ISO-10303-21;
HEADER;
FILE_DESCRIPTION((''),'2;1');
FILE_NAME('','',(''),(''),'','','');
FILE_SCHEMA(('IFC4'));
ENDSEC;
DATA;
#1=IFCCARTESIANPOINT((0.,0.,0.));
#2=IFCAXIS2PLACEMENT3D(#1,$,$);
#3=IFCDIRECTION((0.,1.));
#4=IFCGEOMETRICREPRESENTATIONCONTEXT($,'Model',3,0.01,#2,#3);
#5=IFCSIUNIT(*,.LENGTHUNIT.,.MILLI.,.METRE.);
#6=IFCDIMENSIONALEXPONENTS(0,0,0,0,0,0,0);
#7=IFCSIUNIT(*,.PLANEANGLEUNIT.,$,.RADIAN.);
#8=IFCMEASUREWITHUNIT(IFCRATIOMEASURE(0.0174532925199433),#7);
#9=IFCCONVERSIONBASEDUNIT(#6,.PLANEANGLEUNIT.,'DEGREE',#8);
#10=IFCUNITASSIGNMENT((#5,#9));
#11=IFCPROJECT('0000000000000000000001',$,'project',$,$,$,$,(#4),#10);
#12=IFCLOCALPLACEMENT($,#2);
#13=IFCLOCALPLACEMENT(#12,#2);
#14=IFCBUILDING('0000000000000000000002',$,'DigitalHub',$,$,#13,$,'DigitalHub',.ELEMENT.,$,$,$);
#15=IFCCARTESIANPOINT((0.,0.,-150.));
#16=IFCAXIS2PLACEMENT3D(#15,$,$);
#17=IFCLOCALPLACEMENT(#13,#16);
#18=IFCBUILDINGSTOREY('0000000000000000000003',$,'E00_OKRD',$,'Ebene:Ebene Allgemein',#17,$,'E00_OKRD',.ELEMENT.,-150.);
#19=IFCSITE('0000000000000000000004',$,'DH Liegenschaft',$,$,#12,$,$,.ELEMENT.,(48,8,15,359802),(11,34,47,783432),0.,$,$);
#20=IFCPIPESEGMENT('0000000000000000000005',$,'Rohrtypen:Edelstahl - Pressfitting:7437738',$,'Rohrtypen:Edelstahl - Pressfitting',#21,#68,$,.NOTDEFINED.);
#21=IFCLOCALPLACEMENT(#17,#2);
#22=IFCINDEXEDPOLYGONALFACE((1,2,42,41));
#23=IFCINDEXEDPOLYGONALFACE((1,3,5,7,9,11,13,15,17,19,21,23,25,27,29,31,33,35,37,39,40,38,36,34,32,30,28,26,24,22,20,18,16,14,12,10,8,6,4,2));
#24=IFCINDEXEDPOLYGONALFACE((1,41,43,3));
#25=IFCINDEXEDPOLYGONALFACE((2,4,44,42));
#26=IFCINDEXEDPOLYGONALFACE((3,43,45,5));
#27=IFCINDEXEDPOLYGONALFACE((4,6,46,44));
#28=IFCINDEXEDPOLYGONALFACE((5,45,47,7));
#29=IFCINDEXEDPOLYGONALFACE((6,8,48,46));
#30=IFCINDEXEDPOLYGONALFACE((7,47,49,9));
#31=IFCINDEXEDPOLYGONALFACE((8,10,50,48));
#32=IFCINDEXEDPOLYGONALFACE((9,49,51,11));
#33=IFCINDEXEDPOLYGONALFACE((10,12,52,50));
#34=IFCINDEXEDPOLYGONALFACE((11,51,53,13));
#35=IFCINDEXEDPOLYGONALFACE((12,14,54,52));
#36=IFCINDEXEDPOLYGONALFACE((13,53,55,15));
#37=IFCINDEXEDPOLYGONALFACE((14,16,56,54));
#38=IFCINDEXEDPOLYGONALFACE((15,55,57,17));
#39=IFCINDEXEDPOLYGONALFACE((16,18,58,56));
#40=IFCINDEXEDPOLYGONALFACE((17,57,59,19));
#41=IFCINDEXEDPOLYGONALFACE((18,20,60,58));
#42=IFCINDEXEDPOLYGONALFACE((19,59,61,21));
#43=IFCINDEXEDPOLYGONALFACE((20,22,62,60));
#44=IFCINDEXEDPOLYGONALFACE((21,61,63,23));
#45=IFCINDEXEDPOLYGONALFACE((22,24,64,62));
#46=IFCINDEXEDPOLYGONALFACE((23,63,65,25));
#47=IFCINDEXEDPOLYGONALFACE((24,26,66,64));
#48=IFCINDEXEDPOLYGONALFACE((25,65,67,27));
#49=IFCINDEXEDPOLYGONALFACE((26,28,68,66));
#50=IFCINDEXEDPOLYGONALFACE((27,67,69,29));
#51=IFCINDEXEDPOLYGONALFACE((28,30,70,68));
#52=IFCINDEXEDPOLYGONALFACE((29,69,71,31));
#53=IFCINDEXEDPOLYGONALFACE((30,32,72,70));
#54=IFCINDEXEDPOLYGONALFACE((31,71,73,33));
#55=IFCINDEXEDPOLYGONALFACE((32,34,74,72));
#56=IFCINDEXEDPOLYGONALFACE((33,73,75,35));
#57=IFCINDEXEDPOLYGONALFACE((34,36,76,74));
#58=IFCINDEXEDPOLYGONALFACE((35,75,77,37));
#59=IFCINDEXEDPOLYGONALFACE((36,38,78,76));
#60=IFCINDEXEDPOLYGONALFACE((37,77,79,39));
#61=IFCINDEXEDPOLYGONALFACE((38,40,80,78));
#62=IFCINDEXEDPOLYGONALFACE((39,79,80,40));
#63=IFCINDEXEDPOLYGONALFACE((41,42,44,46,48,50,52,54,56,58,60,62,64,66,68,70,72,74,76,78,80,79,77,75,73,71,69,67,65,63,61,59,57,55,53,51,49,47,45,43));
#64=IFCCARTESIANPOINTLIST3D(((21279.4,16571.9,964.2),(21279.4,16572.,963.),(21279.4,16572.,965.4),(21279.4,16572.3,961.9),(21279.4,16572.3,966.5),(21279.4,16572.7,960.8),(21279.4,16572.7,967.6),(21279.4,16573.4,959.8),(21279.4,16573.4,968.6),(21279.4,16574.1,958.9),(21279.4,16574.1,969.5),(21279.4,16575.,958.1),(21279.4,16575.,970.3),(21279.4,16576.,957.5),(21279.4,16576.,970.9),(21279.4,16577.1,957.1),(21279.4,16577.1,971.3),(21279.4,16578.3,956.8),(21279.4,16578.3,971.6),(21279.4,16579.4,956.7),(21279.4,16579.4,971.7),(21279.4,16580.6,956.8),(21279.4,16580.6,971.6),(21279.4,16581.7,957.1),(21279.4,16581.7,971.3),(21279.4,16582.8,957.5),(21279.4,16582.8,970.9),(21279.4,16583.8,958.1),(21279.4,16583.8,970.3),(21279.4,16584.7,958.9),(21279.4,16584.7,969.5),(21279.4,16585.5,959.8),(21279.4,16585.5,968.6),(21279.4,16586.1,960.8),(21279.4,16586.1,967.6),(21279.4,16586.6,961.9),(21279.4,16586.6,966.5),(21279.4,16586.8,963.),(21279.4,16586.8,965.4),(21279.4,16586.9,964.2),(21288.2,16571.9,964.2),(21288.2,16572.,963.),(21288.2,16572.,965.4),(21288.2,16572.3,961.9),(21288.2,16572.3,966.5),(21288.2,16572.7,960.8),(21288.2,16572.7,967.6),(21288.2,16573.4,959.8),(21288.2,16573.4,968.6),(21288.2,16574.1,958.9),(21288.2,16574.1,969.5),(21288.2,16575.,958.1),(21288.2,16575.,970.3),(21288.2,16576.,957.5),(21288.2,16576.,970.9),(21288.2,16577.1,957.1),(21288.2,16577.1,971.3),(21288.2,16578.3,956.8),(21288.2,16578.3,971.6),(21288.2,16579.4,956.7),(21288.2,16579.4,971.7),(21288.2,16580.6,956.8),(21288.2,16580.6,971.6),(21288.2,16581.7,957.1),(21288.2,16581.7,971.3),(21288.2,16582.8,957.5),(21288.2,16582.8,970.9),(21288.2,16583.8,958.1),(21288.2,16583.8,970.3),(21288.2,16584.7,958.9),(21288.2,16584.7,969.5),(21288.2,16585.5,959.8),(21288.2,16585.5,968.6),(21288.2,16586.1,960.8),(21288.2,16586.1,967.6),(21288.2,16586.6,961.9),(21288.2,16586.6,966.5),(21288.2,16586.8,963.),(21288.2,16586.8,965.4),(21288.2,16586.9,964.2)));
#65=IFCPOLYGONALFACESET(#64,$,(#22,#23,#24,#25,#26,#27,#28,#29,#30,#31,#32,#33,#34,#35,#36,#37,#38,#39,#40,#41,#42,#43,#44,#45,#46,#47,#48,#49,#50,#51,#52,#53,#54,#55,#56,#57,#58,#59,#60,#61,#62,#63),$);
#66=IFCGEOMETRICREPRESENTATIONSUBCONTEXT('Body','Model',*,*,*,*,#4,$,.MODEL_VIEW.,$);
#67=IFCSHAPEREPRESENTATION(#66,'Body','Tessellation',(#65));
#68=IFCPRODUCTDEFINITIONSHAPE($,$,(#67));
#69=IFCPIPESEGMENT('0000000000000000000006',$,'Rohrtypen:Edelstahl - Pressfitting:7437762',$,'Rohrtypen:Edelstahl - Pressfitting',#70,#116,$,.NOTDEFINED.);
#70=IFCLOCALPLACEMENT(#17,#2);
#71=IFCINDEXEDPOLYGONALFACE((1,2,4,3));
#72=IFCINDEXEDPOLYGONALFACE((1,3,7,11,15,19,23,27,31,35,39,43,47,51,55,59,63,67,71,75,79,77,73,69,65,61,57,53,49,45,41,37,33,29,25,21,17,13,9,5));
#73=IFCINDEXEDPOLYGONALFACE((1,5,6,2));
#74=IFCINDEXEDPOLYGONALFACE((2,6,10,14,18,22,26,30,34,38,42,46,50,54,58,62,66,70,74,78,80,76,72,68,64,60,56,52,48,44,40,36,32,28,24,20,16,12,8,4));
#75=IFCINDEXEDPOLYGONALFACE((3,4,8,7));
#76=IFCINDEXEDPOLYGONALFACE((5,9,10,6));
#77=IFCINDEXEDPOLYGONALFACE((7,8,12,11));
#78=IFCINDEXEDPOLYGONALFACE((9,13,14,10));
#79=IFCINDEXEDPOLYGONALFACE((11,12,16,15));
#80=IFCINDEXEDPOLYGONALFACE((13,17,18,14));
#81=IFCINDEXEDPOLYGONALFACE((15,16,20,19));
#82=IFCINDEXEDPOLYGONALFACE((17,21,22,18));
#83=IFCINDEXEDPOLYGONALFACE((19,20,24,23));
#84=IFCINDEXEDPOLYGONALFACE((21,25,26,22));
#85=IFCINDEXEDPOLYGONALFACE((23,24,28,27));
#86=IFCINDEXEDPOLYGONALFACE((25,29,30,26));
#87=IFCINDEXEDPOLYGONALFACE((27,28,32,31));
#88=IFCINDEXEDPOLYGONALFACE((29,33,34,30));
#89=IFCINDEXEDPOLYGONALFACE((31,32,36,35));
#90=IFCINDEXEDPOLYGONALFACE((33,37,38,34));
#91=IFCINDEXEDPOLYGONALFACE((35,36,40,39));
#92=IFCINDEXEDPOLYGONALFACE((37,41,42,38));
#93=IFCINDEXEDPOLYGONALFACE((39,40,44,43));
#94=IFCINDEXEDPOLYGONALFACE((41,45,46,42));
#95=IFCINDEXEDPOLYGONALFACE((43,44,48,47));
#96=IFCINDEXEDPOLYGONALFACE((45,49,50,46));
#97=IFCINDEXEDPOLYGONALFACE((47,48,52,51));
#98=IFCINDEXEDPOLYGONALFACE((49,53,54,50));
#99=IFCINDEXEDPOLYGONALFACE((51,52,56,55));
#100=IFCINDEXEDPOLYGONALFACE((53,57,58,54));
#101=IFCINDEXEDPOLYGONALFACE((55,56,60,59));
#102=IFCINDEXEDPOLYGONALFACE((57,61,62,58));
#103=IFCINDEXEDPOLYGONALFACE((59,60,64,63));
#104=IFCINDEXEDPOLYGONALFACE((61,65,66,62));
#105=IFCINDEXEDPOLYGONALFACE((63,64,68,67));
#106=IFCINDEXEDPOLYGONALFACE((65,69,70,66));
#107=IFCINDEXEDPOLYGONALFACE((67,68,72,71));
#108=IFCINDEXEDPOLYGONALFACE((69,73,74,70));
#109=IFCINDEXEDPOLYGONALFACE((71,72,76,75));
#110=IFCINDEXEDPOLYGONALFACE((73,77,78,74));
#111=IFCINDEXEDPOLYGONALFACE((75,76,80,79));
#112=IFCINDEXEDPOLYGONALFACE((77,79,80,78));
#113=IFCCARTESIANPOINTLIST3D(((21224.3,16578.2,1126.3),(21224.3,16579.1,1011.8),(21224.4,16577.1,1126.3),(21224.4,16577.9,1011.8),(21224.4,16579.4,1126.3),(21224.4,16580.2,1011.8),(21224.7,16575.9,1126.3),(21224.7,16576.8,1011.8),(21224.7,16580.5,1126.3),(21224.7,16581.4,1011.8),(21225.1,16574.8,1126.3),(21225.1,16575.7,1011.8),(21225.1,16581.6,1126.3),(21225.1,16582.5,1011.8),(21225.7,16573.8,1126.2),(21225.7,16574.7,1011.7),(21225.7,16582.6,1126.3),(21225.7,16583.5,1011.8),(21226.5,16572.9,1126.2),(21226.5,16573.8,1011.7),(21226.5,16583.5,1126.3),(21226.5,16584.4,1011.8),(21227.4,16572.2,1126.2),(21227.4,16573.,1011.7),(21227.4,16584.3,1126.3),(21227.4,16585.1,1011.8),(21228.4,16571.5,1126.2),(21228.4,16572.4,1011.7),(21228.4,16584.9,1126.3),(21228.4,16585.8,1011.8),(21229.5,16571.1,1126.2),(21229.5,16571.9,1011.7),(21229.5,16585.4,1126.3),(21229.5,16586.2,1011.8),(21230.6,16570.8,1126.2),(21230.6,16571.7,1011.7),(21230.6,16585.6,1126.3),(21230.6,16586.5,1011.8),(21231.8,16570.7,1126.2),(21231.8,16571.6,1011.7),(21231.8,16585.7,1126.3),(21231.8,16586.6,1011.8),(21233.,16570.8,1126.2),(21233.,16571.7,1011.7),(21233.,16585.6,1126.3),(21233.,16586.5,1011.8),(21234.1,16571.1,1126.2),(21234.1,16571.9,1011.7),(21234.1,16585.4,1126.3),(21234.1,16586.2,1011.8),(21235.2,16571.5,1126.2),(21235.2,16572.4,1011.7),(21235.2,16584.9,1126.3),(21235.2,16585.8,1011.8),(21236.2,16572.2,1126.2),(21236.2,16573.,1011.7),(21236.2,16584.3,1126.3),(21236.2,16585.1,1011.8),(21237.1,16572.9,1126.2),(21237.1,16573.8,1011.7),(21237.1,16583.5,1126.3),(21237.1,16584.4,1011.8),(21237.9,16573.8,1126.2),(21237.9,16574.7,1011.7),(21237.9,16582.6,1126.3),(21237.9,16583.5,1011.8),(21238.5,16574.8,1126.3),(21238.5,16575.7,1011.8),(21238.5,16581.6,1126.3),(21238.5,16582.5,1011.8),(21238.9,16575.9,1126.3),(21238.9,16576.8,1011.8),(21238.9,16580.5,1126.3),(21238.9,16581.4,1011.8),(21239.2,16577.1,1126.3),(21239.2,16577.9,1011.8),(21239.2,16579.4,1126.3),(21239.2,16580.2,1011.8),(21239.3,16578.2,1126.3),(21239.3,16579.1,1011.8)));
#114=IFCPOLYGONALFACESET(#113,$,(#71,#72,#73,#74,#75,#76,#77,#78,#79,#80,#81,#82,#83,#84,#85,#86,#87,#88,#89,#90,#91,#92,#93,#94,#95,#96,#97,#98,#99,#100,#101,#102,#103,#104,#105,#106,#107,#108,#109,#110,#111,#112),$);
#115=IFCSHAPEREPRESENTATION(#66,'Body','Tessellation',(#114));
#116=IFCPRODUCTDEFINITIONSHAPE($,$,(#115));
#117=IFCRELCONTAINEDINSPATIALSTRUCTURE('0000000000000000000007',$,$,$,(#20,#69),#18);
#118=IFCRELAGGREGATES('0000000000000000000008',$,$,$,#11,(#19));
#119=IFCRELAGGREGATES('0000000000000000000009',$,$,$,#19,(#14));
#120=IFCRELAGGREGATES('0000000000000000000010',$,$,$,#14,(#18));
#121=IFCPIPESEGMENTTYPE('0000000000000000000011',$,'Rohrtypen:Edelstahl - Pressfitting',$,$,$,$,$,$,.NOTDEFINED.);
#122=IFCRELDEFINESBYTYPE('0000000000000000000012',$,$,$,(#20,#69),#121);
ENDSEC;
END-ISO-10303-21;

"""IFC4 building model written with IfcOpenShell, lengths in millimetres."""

from ifc_helpers import new_model, entity, si_unit, converted_unit, direction, frame, origin, place, context, subcontext, project, spatial, indexed_curve, outline, extrude, type_object, element, save


model = new_model("IFC4")

# Units and contexts
model_context = context("Model", 3, precision=0.01, world=origin(), true_north=direction((0.0, 1.0)))
body_context = subcontext(model_context, "Body", "Model", "MODEL_VIEW")
ifc_project = project(units=[si_unit("LENGTHUNIT", "METRE", prefix="MILLI"), converted_unit("PLANEANGLEUNIT", "DEGREE", entity("IfcRatioMeasure", 0.0174532925199433), si_unit("PLANEANGLEUNIT", "RADIAN"), dimensions=[0, 0, 0, 0, 0, 0, 0])], contexts=[model_context])

# Site, building, storey
site_placement = place(None, origin())
site = spatial("IfcSite", under=ifc_project, at=site_placement, Name="DH Liegenschaft", CompositionType="ELEMENT", RefLatitude=(48, 8, 15, 359802), RefLongitude=(11, 34, 47, 783432), RefElevation=0.0)
building_placement = place(site_placement, origin())
building = spatial("IfcBuilding", under=site, at=building_placement, Name="DigitalHub", LongName="DigitalHub", CompositionType="ELEMENT")
storey_placement = place(building_placement, frame((0.0, 0.0, -150.0)))
storey = spatial("IfcBuildingStorey", under=building, at=storey_placement, Name="E00_OKRD", ObjectType="Ebene:Ebene Allgemein", LongName="E00_OKRD", CompositionType="ELEMENT", Elevation=-150.0)

# Pipe segments
pipe_segment_type_1 = type_object("IfcPipeSegmentType", Name="Rohrtypen:Edelstahl - Pressfitting", PredefinedType="NOTDEFINED")
pipe_segment_1_placement = place(storey_placement, frame((21279.4, 16570.3, 955.1)))
element("IfcPipeSegment", 1, at=pipe_segment_1_placement, inside=storey, type_object=pipe_segment_type_1, Name="Rohrtypen:Edelstahl - Pressfitting:7437738", ObjectType="Rohrtypen:Edelstahl - Pressfitting", PredefinedType="NOTDEFINED", context=body_context, shape_type="SweptSolid", body=[
    extrude(outline(indexed_curve([(7.5, 0.0), (7.4, 1.2), (7.1, 2.3), (6.7, 3.4), (6.1, 4.4), (5.3, 5.3), (4.4, 6.1), (3.4, 6.7), (2.3, 7.1), (1.2, 7.4), (0.0, 7.5), (-1.2, 7.4), (-2.3, 7.1), (-3.4, 6.7), (-4.4, 6.1), (-5.3, 5.3), (-6.1, 4.4), (-6.7, 3.4), (-7.1, 2.3), (-7.4, 1.2), (-7.5, 0.0), (-7.4, -1.2), (-7.1, -2.3), (-6.7, -3.4), (-6.1, -4.4), (-5.3, -5.3), (-4.4, -6.1), (-3.4, -6.7), (-2.3, -7.1), (-1.2, -7.4), (0.0, -7.5), (1.2, -7.4), (2.3, -7.1), (3.4, -6.7), (4.4, -6.1), (5.3, -5.3), (6.1, -4.4), (6.7, -3.4), (7.1, -2.3), (7.4, -1.2), (7.5, 0.0)], self_intersect=False)), frame((0.0, 9.1, 9.1), z_axis=(1.0, 0.000009, 0.0), x_axis=(-0.000009, 1.0, 0.0)), (0.0, 0.0, 1.0), 8.8),
])
pipe_segment_2_placement = place(storey_placement, frame((21222.7, 16569.1, 1011.7)))
element("IfcPipeSegment", 2, at=pipe_segment_2_placement, inside=storey, type_object=pipe_segment_type_1, Name="Rohrtypen:Edelstahl - Pressfitting:7437762", ObjectType="Rohrtypen:Edelstahl - Pressfitting", PredefinedType="NOTDEFINED", context=body_context, shape_type="SweptSolid", body=[
    extrude(outline(indexed_curve([(7.5, 0.0), (7.4, 1.2), (7.1, 2.3), (6.7, 3.4), (6.1, 4.4), (5.3, 5.3), (4.4, 6.1), (3.4, 6.7), (2.3, 7.1), (1.2, 7.4), (0.0, 7.5), (-1.2, 7.4), (-2.3, 7.1), (-3.4, 6.7), (-4.4, 6.1), (-5.3, 5.3), (-6.1, 4.4), (-6.7, 3.4), (-7.1, 2.3), (-7.4, 1.2), (-7.5, 0.0), (-7.4, -1.2), (-7.1, -2.3), (-6.7, -3.4), (-6.1, -4.4), (-5.3, -5.3), (-4.4, -6.1), (-3.4, -6.7), (-2.3, -7.1), (-1.2, -7.4), (0.0, -7.5), (1.2, -7.4), (2.3, -7.1), (3.4, -6.7), (4.4, -6.1), (5.3, -5.3), (6.1, -4.4), (6.7, -3.4), (7.1, -2.3), (7.4, -1.2), (7.5, 0.0)], self_intersect=False)), frame((9.1, 9.1, 114.6), z_axis=(0.0, 0.007379, -0.999973), x_axis=(-1.0, 0.0, 0.0)), (0.0, 0.0, 1.0), 114.5),
])

save(model, "model.ifc")
